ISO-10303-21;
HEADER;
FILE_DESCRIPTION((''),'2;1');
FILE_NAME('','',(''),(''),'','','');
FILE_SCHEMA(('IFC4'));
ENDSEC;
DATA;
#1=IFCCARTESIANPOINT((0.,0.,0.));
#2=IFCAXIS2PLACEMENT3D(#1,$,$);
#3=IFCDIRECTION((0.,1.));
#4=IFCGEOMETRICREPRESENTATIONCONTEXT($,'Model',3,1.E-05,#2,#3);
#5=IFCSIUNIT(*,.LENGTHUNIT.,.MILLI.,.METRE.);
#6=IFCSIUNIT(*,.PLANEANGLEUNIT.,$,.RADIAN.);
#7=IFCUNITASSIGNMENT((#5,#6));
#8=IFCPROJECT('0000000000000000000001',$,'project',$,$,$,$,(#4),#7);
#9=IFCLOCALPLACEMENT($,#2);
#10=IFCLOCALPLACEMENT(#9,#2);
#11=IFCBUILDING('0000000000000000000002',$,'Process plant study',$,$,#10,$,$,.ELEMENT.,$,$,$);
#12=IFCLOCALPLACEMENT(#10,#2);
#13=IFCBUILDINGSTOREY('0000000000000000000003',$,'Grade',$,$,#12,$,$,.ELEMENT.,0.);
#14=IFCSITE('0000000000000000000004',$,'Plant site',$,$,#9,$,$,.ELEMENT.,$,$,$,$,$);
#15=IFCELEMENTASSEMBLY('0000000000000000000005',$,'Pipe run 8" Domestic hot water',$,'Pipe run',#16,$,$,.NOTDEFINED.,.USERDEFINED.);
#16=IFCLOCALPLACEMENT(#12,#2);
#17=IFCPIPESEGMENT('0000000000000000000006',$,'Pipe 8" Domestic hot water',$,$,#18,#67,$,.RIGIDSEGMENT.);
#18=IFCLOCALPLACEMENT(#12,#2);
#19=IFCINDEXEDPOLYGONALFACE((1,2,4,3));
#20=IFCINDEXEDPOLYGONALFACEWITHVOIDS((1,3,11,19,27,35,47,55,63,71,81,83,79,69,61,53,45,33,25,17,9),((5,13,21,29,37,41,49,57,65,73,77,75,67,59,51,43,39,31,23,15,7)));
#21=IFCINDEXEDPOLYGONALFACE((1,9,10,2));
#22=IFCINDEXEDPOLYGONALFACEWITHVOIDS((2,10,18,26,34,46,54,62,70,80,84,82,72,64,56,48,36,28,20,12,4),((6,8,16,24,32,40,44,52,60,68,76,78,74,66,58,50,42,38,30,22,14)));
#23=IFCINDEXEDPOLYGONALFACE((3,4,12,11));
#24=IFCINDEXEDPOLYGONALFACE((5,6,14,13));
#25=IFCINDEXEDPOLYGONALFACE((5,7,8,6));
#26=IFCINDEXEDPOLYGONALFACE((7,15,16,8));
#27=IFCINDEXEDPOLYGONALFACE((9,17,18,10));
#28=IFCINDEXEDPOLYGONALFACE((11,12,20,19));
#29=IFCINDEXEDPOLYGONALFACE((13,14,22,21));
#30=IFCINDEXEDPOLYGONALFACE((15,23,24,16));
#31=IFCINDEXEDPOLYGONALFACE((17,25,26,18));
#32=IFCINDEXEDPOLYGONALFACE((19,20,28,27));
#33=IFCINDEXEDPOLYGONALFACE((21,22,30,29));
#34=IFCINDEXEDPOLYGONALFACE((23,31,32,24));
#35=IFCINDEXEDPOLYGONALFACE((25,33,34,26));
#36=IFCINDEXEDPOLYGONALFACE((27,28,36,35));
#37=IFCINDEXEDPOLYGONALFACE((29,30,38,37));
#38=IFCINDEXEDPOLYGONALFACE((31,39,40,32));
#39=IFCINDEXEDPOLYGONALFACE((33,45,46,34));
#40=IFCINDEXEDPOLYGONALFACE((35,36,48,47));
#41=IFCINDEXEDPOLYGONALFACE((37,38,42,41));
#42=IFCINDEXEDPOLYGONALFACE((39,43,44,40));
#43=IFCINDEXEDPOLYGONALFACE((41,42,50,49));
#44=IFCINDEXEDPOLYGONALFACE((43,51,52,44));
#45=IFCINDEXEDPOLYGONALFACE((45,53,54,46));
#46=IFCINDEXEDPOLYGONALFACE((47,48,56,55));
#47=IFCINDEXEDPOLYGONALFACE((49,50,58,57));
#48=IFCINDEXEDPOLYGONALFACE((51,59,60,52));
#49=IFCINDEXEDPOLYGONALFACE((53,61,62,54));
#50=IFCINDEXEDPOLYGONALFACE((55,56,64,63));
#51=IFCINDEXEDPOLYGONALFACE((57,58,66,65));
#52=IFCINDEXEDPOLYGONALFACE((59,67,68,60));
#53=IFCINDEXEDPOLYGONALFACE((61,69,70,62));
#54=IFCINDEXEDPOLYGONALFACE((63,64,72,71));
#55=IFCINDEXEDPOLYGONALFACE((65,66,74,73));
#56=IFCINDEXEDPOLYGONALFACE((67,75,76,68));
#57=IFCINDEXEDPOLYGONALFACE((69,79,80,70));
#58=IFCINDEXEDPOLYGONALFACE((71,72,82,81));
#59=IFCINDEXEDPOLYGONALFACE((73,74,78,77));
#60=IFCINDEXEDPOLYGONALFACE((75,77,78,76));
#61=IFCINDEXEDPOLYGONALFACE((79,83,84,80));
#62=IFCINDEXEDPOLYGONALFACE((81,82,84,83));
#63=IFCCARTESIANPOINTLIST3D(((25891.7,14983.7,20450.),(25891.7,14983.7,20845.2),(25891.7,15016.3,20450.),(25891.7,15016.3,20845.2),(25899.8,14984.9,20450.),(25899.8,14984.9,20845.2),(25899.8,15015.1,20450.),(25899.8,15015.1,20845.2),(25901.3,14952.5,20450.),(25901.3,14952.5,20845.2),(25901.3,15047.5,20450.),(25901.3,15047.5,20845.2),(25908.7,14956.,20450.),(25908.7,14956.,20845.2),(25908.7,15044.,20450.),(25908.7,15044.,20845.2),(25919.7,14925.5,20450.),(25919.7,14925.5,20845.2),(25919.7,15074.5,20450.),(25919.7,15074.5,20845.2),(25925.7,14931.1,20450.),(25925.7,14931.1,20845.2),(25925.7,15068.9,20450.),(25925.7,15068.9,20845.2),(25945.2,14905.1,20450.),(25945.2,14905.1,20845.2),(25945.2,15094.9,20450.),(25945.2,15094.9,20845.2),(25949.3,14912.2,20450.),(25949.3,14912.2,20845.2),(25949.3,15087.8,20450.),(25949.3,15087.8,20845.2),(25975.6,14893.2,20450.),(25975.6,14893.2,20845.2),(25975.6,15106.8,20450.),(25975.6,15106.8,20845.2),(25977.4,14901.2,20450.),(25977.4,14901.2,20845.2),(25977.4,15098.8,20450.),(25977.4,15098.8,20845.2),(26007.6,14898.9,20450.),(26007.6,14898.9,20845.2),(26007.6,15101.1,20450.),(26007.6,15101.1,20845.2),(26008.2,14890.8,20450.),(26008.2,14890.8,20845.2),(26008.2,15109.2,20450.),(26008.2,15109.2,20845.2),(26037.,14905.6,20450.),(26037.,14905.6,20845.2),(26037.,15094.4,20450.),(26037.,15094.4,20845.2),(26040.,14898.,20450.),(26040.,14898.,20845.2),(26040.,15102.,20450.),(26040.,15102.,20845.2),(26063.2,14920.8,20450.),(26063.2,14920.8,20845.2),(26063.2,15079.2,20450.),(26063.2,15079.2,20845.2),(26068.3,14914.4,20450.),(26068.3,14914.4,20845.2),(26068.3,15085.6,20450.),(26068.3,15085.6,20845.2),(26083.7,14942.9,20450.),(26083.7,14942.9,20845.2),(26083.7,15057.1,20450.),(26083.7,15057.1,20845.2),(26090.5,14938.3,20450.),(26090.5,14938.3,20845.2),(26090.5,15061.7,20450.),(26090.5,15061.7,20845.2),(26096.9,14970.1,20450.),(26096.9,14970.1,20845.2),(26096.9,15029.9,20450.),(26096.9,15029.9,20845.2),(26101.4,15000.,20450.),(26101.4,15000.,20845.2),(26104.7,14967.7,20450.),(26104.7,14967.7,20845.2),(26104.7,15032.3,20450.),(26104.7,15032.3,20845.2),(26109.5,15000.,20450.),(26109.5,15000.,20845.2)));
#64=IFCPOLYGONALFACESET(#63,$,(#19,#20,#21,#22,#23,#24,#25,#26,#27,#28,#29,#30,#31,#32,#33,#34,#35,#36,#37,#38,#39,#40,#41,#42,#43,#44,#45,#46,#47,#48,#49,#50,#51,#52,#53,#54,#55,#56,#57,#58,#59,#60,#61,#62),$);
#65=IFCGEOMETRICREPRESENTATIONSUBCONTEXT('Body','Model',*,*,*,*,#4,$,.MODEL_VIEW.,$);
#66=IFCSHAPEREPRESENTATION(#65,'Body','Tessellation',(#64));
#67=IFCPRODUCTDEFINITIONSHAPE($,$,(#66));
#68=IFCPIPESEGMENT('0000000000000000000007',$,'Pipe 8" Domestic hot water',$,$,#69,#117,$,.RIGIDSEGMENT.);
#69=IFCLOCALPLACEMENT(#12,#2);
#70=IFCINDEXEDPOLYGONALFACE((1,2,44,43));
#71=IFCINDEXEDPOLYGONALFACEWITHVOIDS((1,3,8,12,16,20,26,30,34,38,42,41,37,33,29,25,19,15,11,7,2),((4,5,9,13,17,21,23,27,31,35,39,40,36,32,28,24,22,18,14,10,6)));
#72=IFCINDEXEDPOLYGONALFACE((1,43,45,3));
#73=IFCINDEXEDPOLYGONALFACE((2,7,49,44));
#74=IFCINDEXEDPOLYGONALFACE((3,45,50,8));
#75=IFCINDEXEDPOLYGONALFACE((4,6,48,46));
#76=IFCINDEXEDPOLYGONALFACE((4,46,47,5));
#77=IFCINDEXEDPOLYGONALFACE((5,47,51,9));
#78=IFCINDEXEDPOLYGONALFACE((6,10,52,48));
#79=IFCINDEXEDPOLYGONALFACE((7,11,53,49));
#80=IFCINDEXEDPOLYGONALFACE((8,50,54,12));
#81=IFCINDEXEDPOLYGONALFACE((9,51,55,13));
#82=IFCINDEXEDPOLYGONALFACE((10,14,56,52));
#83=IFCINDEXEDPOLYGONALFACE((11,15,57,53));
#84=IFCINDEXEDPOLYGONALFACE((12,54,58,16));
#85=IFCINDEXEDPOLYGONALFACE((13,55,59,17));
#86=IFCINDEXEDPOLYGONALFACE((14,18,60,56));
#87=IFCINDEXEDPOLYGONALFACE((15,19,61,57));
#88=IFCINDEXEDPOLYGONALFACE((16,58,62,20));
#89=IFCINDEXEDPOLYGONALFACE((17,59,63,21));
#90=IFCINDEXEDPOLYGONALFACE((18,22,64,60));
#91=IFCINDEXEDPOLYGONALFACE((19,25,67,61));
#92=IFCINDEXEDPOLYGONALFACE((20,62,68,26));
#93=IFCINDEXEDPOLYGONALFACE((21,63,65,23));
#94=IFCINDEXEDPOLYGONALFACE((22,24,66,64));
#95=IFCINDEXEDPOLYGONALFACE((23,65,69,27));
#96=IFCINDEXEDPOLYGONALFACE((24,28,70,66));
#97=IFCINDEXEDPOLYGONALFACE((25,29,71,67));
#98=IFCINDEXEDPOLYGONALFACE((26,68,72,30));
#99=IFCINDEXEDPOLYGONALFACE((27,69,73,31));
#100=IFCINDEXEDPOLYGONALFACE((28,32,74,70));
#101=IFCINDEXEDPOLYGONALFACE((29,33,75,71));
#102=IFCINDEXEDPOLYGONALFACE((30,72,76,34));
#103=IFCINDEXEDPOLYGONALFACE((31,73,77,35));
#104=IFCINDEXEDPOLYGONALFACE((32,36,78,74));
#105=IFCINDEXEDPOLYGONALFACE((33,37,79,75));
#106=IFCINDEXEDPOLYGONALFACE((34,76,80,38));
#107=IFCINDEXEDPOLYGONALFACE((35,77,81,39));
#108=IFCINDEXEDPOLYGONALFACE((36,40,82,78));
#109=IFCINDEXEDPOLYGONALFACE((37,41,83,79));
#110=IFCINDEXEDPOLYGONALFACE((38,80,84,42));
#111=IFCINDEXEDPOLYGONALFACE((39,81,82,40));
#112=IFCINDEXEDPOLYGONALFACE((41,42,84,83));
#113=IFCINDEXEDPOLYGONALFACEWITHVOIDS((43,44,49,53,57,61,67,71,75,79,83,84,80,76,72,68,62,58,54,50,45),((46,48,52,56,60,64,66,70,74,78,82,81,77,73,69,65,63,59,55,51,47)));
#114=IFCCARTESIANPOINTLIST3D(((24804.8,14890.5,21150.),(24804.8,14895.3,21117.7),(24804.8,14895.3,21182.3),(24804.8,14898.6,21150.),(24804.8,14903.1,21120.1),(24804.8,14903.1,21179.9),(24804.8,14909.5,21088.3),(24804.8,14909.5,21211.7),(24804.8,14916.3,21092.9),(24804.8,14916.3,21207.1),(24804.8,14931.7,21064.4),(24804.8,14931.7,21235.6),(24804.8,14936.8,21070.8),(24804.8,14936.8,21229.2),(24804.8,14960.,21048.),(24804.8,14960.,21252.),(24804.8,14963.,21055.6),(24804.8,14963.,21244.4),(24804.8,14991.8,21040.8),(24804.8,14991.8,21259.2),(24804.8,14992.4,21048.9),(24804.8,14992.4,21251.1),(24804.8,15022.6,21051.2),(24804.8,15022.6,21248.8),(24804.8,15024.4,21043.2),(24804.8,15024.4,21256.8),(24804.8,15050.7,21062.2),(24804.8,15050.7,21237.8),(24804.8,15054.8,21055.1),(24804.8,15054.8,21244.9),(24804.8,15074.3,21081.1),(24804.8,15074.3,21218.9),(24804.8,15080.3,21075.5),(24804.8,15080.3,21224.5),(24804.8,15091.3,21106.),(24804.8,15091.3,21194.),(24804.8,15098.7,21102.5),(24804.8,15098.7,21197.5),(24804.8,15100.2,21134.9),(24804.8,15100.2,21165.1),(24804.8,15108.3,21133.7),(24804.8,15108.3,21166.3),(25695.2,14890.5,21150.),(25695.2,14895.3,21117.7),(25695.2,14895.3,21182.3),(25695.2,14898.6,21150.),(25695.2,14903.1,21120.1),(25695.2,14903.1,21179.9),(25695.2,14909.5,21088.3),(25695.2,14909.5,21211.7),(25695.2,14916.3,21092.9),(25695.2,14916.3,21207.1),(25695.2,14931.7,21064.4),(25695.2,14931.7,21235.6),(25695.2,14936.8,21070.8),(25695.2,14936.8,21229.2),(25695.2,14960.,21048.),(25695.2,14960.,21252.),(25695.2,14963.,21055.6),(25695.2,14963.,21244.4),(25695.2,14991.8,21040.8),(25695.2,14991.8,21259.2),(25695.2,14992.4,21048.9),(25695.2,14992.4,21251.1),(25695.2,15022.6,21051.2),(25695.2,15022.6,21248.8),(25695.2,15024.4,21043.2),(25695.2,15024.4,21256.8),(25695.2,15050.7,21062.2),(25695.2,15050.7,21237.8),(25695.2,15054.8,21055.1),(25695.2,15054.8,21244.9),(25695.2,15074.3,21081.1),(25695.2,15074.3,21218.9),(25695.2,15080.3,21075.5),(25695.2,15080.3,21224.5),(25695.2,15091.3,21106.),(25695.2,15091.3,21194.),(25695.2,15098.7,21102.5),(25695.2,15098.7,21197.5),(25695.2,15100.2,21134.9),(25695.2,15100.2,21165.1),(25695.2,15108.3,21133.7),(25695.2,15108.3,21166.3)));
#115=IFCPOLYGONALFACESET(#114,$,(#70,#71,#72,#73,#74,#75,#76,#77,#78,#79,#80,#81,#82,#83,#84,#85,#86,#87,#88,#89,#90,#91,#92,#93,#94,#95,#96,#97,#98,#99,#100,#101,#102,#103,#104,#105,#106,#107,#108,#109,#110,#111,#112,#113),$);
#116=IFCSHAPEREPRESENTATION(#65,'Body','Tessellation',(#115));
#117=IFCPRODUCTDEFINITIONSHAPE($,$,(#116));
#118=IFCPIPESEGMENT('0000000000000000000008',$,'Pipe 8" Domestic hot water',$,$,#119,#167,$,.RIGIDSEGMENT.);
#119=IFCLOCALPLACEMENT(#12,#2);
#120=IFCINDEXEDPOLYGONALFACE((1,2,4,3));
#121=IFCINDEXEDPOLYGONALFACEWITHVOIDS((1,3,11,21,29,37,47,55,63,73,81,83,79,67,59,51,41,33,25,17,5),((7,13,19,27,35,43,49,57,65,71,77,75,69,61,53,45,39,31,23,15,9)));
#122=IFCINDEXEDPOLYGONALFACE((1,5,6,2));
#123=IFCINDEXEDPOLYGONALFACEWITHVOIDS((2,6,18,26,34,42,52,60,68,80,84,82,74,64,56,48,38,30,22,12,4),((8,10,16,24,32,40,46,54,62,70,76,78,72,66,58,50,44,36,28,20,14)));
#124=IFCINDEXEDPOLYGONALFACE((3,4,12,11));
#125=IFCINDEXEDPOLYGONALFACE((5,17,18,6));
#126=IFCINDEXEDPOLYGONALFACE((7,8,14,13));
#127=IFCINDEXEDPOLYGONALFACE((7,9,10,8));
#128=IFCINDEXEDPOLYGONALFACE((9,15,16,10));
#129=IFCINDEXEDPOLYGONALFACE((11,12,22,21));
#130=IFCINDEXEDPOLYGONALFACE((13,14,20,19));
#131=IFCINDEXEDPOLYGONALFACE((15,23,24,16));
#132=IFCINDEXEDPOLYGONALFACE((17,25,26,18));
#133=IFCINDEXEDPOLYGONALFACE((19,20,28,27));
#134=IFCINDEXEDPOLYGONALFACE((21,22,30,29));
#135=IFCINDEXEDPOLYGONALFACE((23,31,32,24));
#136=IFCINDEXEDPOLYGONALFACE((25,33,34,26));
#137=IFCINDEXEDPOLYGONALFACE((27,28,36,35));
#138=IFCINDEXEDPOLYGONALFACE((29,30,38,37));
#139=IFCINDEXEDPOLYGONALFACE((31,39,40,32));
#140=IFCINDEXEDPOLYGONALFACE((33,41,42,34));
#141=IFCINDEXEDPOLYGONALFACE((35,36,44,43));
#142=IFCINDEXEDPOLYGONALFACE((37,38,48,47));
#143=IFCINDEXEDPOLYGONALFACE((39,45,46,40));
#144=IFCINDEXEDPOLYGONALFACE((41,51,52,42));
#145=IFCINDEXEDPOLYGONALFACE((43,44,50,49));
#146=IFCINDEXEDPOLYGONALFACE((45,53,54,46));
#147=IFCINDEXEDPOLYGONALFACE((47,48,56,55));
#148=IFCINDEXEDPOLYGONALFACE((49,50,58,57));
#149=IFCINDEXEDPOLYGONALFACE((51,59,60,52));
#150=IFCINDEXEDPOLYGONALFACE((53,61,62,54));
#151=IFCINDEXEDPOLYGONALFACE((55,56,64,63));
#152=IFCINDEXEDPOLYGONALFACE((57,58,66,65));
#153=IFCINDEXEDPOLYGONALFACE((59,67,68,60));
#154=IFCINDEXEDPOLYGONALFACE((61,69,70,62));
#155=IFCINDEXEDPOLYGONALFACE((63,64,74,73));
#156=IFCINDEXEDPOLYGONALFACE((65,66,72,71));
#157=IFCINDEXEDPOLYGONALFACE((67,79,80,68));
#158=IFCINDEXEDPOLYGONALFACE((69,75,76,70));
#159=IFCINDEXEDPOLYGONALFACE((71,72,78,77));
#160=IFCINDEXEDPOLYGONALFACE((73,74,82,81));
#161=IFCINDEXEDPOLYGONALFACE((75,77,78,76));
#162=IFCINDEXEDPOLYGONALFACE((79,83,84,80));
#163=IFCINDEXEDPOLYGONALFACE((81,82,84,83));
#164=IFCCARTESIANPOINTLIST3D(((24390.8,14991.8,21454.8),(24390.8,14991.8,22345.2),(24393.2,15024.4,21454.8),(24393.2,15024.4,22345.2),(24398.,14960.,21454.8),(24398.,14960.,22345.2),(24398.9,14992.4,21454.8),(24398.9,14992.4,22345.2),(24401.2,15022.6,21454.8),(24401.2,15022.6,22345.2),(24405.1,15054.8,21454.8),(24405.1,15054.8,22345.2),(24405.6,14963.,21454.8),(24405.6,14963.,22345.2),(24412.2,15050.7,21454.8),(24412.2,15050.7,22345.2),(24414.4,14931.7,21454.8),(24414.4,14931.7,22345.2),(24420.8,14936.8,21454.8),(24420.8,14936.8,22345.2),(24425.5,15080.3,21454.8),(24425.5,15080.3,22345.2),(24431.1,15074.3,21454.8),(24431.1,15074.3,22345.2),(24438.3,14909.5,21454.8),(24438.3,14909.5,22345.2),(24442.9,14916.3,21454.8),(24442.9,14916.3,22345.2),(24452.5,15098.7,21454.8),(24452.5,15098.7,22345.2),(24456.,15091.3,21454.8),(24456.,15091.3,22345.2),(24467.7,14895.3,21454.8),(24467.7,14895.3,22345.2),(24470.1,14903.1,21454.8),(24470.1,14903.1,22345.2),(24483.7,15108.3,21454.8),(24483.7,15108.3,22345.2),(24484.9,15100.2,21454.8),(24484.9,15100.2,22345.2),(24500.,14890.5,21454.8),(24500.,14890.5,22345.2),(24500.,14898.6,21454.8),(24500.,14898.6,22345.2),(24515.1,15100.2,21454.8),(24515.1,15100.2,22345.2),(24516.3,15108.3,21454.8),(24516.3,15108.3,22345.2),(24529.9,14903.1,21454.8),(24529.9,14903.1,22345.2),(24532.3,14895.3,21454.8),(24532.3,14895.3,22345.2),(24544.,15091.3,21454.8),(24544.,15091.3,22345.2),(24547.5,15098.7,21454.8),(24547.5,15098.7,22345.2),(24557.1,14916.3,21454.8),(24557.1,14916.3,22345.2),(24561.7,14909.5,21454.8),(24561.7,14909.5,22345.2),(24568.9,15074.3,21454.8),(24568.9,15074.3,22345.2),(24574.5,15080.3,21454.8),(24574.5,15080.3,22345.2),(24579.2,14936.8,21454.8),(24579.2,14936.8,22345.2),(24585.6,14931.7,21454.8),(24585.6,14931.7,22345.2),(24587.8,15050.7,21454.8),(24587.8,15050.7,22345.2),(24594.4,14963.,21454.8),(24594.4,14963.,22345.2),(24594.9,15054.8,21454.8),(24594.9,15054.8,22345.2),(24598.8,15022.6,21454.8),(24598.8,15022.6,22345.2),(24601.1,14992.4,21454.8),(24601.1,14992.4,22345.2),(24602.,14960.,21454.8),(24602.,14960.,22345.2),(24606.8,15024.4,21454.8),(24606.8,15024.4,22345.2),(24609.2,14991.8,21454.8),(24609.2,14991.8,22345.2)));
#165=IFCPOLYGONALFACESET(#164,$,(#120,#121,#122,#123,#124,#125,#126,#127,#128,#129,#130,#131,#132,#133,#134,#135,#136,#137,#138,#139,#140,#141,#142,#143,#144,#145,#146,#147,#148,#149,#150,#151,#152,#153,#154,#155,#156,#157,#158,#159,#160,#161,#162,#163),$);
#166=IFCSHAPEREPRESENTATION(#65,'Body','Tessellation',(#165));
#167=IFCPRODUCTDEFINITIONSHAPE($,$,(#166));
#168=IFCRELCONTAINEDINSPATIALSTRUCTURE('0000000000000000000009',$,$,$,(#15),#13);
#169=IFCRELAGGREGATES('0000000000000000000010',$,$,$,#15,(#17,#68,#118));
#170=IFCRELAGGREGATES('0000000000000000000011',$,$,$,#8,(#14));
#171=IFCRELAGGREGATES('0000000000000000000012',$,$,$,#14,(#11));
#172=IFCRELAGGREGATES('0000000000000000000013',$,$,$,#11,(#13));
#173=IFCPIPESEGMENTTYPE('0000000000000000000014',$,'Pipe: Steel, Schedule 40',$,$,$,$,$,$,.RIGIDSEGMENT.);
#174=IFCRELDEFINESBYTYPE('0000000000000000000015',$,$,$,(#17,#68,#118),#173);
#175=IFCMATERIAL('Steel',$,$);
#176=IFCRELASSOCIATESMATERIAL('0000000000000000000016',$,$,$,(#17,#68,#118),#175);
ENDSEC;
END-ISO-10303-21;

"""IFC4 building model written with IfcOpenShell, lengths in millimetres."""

from ifc_helpers import new_model, si_unit, direction, frame, origin, origin_with_axes, origin_2d, place, context, subcontext, project, spatial, hollow_circle, extrude, material, type_object, element, aggregate, save


model = new_model("IFC4")

# Units and contexts
model_context = context("Model", 3, precision=1e-05, world=origin(), true_north=direction((0.0, 1.0)))
body_context = subcontext(model_context, "Body", "Model", "MODEL_VIEW")
ifc_project = project(units=[si_unit("LENGTHUNIT", "METRE", prefix="MILLI"), si_unit("PLANEANGLEUNIT", "RADIAN")], contexts=[model_context])

# Site, building, storey
site_placement = place(None, origin())
site = spatial("IfcSite", under=ifc_project, at=site_placement, Name="Plant site", CompositionType="ELEMENT")
building_placement = place(site_placement, origin())
building = spatial("IfcBuilding", under=site, at=building_placement, Name="Process plant study", CompositionType="ELEMENT")
storey_placement = place(building_placement, origin())
storey = spatial("IfcBuildingStorey", under=building, at=storey_placement, Name="Grade", CompositionType="ELEMENT", Elevation=0.0)

# Element assembly, pipe segments
assembly_1_placement = place(storey_placement, origin_with_axes())
assembly_1 = element("IfcElementAssembly", 1, at=assembly_1_placement, inside=storey, Name="Pipe run 8\" Domestic hot water", ObjectType="Pipe run", AssemblyPlace="NOTDEFINED", PredefinedType="USERDEFINED")
ifc_material = material(Name="Steel")
pipe_segment_type = type_object("IfcPipeSegmentType", Name="Pipe: Steel, Schedule 40", PredefinedType="RIGIDSEGMENT")
pipe_segment_1_placement = place(storey_placement, origin_with_axes())
pipe_segment_1 = element("IfcPipeSegment", 2, at=pipe_segment_1_placement, type_object=pipe_segment_type, material=ifc_material, Name="Pipe 8\" Domestic hot water", PredefinedType="RIGIDSEGMENT", context=body_context, shape_type="SweptSolid", body=[
    extrude(hollow_circle(Radius=109.5, WallThickness=8.2, at=origin_2d()), frame((26000.0, 15000.0, 20450.0), z_axis=(0.0, 0.0, 1.0), x_axis=(1.0, 0.0, 0.0)), (0.0, 0.0, 1.0), 395.2),
])
pipe_segment_2_placement = place(storey_placement, origin_with_axes())
pipe_segment_2 = element("IfcPipeSegment", 3, at=pipe_segment_2_placement, type_object=pipe_segment_type, material=ifc_material, Name="Pipe 8\" Domestic hot water", PredefinedType="RIGIDSEGMENT", context=body_context, shape_type="SweptSolid", body=[
    extrude(hollow_circle(Radius=109.5, WallThickness=8.2, at=origin_2d()), frame((25695.2, 15000.0, 21150.0), z_axis=(-1.0, 0.0, 0.0), x_axis=(0.0, -1.0, 0.0)), (0.0, 0.0, 1.0), 890.4),
])
pipe_segment_3_placement = place(storey_placement, origin_with_axes())
pipe_segment_3 = element("IfcPipeSegment", 4, at=pipe_segment_3_placement, type_object=pipe_segment_type, material=ifc_material, Name="Pipe 8\" Domestic hot water", PredefinedType="RIGIDSEGMENT", context=body_context, shape_type="SweptSolid", body=[
    extrude(hollow_circle(Radius=109.5, WallThickness=8.2, at=origin_2d()), frame((24500.0, 15000.0, 21454.8), z_axis=(0.0, 0.0, 1.0), x_axis=(0.0, -1.0, 0.0)), (0.0, 0.0, 1.0), 890.4),
])

aggregate(assembly_1, [pipe_segment_1, pipe_segment_2, pipe_segment_3])

save(model, "model.ifc")
